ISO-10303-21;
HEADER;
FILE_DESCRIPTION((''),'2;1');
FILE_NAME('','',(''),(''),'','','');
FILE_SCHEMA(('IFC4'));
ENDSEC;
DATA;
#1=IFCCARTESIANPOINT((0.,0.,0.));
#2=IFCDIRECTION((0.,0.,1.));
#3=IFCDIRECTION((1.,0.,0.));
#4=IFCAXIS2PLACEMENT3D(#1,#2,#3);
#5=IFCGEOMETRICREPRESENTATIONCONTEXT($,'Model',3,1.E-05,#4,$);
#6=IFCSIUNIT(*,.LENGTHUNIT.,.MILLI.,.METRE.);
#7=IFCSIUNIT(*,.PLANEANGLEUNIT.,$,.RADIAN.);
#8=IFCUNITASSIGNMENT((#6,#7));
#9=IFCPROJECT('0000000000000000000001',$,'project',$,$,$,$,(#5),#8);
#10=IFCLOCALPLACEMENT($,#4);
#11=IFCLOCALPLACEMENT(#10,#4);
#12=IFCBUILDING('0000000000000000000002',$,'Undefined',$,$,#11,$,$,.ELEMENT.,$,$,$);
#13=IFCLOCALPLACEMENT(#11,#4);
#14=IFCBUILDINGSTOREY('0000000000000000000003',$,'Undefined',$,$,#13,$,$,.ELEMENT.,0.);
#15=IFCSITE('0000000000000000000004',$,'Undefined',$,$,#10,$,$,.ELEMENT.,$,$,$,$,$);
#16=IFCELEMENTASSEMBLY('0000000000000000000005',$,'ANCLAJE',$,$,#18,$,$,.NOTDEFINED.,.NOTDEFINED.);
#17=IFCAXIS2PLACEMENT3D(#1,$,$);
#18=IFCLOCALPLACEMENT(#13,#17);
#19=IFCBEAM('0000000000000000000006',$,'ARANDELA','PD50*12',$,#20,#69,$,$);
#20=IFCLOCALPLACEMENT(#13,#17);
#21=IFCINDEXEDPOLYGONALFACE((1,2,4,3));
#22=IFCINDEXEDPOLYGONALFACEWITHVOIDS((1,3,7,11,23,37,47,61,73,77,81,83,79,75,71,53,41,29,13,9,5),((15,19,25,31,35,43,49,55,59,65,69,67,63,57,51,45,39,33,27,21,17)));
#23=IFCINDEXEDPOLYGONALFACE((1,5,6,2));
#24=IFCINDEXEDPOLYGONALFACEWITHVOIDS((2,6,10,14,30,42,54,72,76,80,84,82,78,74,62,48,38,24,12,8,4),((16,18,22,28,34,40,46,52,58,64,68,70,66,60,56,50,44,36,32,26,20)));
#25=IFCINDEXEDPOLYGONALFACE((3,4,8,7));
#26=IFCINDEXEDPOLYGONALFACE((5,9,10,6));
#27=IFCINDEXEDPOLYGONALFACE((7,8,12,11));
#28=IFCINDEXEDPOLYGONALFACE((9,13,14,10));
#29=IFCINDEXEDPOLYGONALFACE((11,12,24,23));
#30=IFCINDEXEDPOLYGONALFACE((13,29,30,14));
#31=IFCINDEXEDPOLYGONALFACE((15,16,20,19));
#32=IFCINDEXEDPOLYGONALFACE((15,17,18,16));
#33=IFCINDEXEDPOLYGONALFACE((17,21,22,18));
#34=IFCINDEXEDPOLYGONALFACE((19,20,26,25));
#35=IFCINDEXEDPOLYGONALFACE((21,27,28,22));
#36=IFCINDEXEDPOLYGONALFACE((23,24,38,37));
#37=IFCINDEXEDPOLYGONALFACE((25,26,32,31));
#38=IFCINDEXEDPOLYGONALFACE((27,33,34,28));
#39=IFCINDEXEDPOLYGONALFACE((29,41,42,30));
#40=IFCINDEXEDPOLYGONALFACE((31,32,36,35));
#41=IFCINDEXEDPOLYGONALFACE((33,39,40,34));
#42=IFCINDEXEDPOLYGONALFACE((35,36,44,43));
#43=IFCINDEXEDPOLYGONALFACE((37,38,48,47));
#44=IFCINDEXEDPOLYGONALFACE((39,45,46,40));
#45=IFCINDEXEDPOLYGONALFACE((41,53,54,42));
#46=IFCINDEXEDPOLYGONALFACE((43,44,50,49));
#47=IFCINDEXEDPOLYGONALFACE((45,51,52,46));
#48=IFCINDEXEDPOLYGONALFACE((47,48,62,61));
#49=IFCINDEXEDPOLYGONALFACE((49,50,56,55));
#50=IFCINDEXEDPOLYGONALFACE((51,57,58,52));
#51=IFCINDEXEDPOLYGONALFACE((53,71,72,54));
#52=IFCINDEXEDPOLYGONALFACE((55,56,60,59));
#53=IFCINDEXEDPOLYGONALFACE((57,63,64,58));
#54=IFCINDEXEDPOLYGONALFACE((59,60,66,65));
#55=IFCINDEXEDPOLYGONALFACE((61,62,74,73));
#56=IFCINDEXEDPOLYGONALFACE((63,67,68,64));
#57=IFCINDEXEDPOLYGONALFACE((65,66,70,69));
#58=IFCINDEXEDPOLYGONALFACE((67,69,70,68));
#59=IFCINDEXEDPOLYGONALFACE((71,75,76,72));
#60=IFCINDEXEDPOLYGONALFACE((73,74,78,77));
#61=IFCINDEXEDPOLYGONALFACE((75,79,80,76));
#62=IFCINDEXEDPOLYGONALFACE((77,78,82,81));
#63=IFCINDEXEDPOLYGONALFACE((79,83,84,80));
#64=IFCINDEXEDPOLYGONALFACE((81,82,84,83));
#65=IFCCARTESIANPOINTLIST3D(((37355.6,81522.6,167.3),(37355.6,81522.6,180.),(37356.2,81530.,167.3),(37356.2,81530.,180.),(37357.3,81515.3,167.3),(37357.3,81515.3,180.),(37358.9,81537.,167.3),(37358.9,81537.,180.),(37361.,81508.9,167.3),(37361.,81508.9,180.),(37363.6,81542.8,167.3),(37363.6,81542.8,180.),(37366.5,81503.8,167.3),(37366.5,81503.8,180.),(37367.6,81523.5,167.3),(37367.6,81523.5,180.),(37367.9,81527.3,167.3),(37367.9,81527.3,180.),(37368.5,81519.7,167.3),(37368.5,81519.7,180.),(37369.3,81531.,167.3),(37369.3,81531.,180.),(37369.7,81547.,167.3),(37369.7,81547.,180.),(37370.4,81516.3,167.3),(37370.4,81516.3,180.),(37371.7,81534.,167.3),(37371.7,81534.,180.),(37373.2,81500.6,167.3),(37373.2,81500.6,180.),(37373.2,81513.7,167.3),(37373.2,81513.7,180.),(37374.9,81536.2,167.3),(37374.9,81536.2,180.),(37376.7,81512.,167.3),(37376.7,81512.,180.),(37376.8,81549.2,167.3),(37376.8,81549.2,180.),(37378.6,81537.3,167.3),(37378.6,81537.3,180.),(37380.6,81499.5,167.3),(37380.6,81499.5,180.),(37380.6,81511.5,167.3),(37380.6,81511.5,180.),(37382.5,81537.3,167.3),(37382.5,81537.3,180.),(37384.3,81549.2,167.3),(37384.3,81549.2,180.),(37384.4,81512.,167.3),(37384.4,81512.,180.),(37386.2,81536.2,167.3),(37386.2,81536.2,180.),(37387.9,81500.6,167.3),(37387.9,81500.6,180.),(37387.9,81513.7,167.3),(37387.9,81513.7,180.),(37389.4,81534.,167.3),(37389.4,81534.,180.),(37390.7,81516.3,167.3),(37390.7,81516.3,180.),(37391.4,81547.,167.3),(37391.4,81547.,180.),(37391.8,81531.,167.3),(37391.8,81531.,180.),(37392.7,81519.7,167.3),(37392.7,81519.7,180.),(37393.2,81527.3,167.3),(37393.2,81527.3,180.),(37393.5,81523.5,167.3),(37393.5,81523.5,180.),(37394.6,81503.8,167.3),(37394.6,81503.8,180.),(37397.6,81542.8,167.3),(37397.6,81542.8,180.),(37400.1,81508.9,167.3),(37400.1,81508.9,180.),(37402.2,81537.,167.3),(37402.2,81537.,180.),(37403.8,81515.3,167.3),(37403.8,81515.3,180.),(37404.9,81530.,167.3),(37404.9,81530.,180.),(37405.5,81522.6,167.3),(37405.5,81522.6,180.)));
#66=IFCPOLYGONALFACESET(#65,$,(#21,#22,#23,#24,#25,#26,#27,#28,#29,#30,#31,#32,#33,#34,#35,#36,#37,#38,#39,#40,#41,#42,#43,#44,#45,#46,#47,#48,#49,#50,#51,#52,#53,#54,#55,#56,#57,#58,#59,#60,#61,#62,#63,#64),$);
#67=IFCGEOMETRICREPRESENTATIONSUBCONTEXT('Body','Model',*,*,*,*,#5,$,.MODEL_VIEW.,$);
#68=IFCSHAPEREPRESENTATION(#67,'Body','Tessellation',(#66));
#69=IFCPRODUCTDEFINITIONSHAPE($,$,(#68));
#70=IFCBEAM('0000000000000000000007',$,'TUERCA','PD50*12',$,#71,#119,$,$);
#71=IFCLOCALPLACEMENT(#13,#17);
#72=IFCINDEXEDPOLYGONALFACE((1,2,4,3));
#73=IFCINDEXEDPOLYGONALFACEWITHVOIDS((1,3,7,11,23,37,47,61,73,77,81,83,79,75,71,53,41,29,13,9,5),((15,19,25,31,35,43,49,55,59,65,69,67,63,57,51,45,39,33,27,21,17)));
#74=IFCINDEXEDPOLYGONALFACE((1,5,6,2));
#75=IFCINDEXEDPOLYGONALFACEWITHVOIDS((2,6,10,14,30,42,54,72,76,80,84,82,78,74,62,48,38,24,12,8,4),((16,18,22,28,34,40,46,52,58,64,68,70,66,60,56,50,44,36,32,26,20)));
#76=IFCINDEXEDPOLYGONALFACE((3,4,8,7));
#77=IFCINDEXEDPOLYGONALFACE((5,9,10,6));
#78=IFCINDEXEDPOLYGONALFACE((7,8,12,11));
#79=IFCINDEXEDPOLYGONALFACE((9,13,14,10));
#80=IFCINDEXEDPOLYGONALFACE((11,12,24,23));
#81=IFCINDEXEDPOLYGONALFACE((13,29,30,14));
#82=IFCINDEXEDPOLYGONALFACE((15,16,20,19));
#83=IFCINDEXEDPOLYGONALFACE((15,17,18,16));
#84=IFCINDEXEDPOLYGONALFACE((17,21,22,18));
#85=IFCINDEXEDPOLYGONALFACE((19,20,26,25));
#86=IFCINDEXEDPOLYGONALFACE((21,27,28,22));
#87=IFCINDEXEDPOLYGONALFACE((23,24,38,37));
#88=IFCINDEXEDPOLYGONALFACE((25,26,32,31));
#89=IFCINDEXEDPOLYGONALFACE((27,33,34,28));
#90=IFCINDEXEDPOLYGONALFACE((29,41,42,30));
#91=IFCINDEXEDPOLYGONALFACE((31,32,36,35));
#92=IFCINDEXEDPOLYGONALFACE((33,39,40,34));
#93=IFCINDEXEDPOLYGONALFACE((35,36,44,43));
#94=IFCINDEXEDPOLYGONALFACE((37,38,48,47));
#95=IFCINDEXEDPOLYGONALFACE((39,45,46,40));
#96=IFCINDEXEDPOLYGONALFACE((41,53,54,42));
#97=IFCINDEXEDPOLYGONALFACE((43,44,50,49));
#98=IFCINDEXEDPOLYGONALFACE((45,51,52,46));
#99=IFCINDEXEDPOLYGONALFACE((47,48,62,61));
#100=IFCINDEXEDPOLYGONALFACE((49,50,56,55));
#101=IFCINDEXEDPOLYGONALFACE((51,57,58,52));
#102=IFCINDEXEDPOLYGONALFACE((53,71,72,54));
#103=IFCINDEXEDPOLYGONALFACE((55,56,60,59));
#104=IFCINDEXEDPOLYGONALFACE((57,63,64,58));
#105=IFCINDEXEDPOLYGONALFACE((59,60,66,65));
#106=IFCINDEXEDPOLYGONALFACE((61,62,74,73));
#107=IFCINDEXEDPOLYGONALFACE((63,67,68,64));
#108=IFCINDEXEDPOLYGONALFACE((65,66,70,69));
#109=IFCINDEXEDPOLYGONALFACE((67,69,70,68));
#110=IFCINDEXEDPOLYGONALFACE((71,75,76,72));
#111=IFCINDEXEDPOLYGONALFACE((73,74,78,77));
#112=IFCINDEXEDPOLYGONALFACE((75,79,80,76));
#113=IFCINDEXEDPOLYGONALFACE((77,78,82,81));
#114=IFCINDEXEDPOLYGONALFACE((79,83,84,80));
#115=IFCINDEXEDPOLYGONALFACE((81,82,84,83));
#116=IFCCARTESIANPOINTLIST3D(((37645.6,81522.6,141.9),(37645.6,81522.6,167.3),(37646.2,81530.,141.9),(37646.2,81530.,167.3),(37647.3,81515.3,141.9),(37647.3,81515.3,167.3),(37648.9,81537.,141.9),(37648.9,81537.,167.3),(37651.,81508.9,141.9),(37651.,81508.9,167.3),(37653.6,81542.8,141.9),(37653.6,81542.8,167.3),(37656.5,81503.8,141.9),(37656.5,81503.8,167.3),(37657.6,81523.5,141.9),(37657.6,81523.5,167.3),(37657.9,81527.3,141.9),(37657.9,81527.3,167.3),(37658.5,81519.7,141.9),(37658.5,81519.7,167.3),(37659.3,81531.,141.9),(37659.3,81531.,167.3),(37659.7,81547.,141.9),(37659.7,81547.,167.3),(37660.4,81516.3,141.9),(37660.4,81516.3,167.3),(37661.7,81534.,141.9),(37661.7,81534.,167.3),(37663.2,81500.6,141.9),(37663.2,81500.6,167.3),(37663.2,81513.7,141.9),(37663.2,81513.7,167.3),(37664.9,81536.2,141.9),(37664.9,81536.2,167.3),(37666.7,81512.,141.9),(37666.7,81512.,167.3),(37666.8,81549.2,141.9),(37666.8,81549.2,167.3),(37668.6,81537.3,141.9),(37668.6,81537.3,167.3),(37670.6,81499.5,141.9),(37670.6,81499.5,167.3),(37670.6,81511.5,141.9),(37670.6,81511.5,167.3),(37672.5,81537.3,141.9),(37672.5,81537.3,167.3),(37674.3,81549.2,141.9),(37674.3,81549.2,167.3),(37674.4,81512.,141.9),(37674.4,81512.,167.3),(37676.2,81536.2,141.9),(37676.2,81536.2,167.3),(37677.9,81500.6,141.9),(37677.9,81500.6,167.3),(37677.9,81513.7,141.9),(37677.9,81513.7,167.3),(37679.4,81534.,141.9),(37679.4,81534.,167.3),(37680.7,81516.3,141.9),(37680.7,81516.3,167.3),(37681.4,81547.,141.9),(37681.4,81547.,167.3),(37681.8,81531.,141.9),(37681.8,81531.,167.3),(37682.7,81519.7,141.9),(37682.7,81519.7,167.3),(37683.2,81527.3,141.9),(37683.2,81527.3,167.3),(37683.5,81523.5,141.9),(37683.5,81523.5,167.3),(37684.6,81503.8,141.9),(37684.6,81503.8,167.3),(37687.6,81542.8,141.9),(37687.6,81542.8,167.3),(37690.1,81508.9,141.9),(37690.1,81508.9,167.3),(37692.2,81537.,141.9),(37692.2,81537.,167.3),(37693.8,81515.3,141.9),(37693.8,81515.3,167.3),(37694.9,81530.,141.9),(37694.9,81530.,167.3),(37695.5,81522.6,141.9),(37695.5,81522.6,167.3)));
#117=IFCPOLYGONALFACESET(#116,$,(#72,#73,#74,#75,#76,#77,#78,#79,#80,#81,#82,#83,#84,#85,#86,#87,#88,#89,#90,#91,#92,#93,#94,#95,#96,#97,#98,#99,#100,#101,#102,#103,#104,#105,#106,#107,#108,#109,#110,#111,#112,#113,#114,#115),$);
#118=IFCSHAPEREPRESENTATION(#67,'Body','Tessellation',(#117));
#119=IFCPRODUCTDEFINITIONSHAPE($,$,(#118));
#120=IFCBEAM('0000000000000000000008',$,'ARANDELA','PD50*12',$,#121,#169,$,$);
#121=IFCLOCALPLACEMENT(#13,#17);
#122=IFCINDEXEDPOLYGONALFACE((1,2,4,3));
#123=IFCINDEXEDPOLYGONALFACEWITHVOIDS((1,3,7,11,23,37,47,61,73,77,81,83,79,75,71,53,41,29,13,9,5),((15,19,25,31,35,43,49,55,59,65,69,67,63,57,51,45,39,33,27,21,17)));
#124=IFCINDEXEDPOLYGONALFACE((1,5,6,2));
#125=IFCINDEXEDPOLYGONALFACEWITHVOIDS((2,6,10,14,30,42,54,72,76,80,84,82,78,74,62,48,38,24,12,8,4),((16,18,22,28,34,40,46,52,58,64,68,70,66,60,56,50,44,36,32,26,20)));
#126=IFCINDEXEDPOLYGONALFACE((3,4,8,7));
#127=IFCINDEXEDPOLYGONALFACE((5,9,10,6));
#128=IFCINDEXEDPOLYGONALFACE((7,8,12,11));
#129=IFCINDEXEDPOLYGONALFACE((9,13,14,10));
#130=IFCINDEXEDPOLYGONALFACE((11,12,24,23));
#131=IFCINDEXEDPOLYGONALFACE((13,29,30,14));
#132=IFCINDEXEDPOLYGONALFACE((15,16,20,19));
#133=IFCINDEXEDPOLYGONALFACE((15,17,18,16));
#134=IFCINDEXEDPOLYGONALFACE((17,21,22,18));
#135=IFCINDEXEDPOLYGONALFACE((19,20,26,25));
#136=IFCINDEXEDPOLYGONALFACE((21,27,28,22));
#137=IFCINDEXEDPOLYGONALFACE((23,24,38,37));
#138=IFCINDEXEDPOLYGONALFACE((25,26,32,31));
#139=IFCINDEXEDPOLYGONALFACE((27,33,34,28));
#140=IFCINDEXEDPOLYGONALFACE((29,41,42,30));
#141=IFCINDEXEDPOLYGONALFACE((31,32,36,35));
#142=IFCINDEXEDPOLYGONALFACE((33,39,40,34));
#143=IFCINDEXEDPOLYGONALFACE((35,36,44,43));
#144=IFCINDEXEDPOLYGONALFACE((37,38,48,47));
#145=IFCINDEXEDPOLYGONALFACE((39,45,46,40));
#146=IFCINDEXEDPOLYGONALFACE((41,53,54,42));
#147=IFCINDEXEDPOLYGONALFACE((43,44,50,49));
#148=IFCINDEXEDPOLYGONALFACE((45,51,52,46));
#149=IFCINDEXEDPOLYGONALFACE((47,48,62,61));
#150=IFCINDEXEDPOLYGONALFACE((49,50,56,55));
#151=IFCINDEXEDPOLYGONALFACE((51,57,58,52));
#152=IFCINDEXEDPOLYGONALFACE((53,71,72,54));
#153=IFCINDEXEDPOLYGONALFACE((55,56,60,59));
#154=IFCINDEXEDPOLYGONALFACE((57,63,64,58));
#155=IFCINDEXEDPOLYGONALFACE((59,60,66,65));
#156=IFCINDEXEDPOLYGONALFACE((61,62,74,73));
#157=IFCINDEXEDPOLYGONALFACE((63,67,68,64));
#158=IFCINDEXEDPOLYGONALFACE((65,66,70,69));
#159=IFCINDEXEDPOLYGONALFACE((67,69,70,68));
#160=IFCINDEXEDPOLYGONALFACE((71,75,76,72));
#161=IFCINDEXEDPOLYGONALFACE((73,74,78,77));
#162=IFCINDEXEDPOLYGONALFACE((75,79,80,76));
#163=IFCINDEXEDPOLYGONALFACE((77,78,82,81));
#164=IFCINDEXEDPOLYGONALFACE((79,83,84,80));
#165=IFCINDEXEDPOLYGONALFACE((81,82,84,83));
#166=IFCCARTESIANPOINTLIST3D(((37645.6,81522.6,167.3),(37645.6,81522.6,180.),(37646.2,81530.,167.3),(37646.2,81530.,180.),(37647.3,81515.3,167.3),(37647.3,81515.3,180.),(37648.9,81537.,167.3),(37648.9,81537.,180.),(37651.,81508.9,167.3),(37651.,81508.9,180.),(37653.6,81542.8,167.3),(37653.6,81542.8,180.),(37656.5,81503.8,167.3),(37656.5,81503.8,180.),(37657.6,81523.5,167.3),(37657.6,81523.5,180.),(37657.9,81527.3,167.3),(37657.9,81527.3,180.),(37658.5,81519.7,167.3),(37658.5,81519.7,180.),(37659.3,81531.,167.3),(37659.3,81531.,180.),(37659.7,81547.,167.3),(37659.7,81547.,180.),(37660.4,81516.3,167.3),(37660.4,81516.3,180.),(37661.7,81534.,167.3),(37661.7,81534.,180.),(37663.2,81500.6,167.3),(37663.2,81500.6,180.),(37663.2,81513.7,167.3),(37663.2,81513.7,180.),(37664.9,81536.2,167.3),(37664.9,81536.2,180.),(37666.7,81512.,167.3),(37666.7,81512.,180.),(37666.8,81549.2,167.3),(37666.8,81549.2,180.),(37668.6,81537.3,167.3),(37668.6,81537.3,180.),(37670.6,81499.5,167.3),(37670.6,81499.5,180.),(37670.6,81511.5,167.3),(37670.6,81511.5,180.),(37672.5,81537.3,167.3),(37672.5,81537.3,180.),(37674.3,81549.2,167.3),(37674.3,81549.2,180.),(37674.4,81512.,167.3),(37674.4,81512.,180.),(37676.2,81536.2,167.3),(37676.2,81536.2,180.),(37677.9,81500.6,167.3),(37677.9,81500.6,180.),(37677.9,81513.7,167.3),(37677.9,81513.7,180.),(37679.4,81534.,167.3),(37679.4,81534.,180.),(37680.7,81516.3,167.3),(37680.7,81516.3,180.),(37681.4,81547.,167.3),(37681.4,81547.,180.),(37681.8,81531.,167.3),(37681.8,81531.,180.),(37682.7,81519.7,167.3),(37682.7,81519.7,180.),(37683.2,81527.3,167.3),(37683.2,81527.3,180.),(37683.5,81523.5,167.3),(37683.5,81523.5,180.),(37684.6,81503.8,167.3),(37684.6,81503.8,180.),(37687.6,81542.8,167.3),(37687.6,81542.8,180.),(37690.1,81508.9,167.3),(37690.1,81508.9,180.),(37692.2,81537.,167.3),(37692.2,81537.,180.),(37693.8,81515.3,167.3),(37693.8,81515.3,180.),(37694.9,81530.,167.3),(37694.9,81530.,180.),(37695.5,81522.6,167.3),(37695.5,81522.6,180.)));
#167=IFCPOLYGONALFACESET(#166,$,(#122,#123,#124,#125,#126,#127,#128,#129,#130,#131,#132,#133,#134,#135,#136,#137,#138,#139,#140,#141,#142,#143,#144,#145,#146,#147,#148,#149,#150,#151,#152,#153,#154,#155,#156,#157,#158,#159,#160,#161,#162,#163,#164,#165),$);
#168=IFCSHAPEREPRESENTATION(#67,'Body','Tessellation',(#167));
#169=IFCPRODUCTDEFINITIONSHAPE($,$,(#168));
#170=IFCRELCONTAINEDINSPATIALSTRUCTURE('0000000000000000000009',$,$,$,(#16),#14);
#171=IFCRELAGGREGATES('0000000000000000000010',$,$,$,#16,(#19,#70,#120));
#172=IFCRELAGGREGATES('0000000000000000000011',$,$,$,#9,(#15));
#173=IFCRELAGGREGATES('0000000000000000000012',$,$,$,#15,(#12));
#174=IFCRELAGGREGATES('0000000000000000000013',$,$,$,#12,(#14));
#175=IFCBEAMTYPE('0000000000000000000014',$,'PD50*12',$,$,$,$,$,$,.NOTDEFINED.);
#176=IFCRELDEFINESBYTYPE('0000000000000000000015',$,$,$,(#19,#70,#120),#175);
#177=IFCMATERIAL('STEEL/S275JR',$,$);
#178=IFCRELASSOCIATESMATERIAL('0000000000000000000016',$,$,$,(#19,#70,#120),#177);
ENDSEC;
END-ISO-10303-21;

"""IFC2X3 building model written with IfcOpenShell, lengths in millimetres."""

from ifc_helpers import new_model, si_unit, frame, origin_with_axes, origin_2d_with_axis, place, context, subcontext, project, spatial, hollow_circle, extrude, material, type_object, element, aggregate, save


model = new_model("IFC2X3")

# Units and contexts
model_context = context("Model", 3, precision=1e-05, world=origin_with_axes())
body_context = subcontext(model_context, "Body", "Model", "MODEL_VIEW")
ifc_project = project(units=[si_unit("LENGTHUNIT", "METRE", prefix="MILLI"), si_unit("PLANEANGLEUNIT", "RADIAN")], contexts=[model_context])

# Site, building, storey
site_placement = place(None, origin_with_axes())
site = spatial("IfcSite", under=ifc_project, at=site_placement, Name="Undefined", CompositionType="ELEMENT")
building_placement = place(site_placement, origin_with_axes())
building = spatial("IfcBuilding", under=site, at=building_placement, Name="Undefined", CompositionType="ELEMENT")
storey_placement = place(building_placement, origin_with_axes())
storey = spatial("IfcBuildingStorey", under=building, at=storey_placement, Name="Undefined", CompositionType="ELEMENT", Elevation=0.0)

# Element assembly, beams
ifc_material_1 = material(Name="STEEL/S275JR")
beam_type = type_object("IfcBeamType", Name="PD50*12", PredefinedType="NOTDEFINED")
assembly_1_placement = place(storey_placement, origin_with_axes())
assembly_1 = element("IfcElementAssembly", 1, at=assembly_1_placement, inside=storey, Name="ANCLAJE", AssemblyPlace="NOTDEFINED", PredefinedType="NOTDEFINED")
beam_1_placement = place(assembly_1_placement, frame((37380.6, 81524.5, 180.0), z_axis=(1.0, 0.0, 0.0), x_axis=(0.0, 0.0, -1.0)))
beam_1 = element("IfcBeam", 2, at=beam_1_placement, type_object=beam_type, material=ifc_material_1, Name="ARANDELA", Description="PD50*12", context=body_context, shape_type="SweptSolid", body=[
    extrude(hollow_circle(Radius=25.0, WallThickness=12.0, at=origin_2d_with_axis()), frame((12.7, 0.0, 0.0), z_axis=(-1.0, 0.0, 0.0), x_axis=(0.0, -1.0, 0.0)), (0.0, 0.0, 1.0), 12.7),
])
beam_2_placement = place(assembly_1_placement, frame((37670.6, 81524.5, 167.3), z_axis=(1.0, 0.0, 0.0), x_axis=(0.0, 0.0, -1.0)))
beam_2 = element("IfcBeam", 3, at=beam_2_placement, type_object=beam_type, material=ifc_material_1, Name="TUERCA", Description="PD50*12", context=body_context, shape_type="SweptSolid", body=[
    extrude(hollow_circle(Radius=25.0, WallThickness=12.0, at=origin_2d_with_axis()), frame((25.4, 0.0, 0.0), z_axis=(-1.0, 0.0, 0.0), x_axis=(0.0, -1.0, 0.0)), (0.0, 0.0, 1.0), 25.4),
])
beam_3_placement = place(assembly_1_placement, frame((37670.6, 81524.5, 180.0), z_axis=(1.0, 0.0, 0.0), x_axis=(0.0, 0.0, -1.0)))
beam_3 = element("IfcBeam", 4, at=beam_3_placement, type_object=beam_type, material=ifc_material_1, Name="ARANDELA", Description="PD50*12", context=body_context, shape_type="SweptSolid", body=[
    extrude(hollow_circle(Radius=25.0, WallThickness=12.0, at=origin_2d_with_axis()), frame((12.7, 0.0, 0.0), z_axis=(-1.0, 0.0, 0.0), x_axis=(0.0, -1.0, 0.0)), (0.0, 0.0, 1.0), 12.7),
])

aggregate(assembly_1, [beam_1, beam_2, beam_3])

save(model, "model.ifc")
